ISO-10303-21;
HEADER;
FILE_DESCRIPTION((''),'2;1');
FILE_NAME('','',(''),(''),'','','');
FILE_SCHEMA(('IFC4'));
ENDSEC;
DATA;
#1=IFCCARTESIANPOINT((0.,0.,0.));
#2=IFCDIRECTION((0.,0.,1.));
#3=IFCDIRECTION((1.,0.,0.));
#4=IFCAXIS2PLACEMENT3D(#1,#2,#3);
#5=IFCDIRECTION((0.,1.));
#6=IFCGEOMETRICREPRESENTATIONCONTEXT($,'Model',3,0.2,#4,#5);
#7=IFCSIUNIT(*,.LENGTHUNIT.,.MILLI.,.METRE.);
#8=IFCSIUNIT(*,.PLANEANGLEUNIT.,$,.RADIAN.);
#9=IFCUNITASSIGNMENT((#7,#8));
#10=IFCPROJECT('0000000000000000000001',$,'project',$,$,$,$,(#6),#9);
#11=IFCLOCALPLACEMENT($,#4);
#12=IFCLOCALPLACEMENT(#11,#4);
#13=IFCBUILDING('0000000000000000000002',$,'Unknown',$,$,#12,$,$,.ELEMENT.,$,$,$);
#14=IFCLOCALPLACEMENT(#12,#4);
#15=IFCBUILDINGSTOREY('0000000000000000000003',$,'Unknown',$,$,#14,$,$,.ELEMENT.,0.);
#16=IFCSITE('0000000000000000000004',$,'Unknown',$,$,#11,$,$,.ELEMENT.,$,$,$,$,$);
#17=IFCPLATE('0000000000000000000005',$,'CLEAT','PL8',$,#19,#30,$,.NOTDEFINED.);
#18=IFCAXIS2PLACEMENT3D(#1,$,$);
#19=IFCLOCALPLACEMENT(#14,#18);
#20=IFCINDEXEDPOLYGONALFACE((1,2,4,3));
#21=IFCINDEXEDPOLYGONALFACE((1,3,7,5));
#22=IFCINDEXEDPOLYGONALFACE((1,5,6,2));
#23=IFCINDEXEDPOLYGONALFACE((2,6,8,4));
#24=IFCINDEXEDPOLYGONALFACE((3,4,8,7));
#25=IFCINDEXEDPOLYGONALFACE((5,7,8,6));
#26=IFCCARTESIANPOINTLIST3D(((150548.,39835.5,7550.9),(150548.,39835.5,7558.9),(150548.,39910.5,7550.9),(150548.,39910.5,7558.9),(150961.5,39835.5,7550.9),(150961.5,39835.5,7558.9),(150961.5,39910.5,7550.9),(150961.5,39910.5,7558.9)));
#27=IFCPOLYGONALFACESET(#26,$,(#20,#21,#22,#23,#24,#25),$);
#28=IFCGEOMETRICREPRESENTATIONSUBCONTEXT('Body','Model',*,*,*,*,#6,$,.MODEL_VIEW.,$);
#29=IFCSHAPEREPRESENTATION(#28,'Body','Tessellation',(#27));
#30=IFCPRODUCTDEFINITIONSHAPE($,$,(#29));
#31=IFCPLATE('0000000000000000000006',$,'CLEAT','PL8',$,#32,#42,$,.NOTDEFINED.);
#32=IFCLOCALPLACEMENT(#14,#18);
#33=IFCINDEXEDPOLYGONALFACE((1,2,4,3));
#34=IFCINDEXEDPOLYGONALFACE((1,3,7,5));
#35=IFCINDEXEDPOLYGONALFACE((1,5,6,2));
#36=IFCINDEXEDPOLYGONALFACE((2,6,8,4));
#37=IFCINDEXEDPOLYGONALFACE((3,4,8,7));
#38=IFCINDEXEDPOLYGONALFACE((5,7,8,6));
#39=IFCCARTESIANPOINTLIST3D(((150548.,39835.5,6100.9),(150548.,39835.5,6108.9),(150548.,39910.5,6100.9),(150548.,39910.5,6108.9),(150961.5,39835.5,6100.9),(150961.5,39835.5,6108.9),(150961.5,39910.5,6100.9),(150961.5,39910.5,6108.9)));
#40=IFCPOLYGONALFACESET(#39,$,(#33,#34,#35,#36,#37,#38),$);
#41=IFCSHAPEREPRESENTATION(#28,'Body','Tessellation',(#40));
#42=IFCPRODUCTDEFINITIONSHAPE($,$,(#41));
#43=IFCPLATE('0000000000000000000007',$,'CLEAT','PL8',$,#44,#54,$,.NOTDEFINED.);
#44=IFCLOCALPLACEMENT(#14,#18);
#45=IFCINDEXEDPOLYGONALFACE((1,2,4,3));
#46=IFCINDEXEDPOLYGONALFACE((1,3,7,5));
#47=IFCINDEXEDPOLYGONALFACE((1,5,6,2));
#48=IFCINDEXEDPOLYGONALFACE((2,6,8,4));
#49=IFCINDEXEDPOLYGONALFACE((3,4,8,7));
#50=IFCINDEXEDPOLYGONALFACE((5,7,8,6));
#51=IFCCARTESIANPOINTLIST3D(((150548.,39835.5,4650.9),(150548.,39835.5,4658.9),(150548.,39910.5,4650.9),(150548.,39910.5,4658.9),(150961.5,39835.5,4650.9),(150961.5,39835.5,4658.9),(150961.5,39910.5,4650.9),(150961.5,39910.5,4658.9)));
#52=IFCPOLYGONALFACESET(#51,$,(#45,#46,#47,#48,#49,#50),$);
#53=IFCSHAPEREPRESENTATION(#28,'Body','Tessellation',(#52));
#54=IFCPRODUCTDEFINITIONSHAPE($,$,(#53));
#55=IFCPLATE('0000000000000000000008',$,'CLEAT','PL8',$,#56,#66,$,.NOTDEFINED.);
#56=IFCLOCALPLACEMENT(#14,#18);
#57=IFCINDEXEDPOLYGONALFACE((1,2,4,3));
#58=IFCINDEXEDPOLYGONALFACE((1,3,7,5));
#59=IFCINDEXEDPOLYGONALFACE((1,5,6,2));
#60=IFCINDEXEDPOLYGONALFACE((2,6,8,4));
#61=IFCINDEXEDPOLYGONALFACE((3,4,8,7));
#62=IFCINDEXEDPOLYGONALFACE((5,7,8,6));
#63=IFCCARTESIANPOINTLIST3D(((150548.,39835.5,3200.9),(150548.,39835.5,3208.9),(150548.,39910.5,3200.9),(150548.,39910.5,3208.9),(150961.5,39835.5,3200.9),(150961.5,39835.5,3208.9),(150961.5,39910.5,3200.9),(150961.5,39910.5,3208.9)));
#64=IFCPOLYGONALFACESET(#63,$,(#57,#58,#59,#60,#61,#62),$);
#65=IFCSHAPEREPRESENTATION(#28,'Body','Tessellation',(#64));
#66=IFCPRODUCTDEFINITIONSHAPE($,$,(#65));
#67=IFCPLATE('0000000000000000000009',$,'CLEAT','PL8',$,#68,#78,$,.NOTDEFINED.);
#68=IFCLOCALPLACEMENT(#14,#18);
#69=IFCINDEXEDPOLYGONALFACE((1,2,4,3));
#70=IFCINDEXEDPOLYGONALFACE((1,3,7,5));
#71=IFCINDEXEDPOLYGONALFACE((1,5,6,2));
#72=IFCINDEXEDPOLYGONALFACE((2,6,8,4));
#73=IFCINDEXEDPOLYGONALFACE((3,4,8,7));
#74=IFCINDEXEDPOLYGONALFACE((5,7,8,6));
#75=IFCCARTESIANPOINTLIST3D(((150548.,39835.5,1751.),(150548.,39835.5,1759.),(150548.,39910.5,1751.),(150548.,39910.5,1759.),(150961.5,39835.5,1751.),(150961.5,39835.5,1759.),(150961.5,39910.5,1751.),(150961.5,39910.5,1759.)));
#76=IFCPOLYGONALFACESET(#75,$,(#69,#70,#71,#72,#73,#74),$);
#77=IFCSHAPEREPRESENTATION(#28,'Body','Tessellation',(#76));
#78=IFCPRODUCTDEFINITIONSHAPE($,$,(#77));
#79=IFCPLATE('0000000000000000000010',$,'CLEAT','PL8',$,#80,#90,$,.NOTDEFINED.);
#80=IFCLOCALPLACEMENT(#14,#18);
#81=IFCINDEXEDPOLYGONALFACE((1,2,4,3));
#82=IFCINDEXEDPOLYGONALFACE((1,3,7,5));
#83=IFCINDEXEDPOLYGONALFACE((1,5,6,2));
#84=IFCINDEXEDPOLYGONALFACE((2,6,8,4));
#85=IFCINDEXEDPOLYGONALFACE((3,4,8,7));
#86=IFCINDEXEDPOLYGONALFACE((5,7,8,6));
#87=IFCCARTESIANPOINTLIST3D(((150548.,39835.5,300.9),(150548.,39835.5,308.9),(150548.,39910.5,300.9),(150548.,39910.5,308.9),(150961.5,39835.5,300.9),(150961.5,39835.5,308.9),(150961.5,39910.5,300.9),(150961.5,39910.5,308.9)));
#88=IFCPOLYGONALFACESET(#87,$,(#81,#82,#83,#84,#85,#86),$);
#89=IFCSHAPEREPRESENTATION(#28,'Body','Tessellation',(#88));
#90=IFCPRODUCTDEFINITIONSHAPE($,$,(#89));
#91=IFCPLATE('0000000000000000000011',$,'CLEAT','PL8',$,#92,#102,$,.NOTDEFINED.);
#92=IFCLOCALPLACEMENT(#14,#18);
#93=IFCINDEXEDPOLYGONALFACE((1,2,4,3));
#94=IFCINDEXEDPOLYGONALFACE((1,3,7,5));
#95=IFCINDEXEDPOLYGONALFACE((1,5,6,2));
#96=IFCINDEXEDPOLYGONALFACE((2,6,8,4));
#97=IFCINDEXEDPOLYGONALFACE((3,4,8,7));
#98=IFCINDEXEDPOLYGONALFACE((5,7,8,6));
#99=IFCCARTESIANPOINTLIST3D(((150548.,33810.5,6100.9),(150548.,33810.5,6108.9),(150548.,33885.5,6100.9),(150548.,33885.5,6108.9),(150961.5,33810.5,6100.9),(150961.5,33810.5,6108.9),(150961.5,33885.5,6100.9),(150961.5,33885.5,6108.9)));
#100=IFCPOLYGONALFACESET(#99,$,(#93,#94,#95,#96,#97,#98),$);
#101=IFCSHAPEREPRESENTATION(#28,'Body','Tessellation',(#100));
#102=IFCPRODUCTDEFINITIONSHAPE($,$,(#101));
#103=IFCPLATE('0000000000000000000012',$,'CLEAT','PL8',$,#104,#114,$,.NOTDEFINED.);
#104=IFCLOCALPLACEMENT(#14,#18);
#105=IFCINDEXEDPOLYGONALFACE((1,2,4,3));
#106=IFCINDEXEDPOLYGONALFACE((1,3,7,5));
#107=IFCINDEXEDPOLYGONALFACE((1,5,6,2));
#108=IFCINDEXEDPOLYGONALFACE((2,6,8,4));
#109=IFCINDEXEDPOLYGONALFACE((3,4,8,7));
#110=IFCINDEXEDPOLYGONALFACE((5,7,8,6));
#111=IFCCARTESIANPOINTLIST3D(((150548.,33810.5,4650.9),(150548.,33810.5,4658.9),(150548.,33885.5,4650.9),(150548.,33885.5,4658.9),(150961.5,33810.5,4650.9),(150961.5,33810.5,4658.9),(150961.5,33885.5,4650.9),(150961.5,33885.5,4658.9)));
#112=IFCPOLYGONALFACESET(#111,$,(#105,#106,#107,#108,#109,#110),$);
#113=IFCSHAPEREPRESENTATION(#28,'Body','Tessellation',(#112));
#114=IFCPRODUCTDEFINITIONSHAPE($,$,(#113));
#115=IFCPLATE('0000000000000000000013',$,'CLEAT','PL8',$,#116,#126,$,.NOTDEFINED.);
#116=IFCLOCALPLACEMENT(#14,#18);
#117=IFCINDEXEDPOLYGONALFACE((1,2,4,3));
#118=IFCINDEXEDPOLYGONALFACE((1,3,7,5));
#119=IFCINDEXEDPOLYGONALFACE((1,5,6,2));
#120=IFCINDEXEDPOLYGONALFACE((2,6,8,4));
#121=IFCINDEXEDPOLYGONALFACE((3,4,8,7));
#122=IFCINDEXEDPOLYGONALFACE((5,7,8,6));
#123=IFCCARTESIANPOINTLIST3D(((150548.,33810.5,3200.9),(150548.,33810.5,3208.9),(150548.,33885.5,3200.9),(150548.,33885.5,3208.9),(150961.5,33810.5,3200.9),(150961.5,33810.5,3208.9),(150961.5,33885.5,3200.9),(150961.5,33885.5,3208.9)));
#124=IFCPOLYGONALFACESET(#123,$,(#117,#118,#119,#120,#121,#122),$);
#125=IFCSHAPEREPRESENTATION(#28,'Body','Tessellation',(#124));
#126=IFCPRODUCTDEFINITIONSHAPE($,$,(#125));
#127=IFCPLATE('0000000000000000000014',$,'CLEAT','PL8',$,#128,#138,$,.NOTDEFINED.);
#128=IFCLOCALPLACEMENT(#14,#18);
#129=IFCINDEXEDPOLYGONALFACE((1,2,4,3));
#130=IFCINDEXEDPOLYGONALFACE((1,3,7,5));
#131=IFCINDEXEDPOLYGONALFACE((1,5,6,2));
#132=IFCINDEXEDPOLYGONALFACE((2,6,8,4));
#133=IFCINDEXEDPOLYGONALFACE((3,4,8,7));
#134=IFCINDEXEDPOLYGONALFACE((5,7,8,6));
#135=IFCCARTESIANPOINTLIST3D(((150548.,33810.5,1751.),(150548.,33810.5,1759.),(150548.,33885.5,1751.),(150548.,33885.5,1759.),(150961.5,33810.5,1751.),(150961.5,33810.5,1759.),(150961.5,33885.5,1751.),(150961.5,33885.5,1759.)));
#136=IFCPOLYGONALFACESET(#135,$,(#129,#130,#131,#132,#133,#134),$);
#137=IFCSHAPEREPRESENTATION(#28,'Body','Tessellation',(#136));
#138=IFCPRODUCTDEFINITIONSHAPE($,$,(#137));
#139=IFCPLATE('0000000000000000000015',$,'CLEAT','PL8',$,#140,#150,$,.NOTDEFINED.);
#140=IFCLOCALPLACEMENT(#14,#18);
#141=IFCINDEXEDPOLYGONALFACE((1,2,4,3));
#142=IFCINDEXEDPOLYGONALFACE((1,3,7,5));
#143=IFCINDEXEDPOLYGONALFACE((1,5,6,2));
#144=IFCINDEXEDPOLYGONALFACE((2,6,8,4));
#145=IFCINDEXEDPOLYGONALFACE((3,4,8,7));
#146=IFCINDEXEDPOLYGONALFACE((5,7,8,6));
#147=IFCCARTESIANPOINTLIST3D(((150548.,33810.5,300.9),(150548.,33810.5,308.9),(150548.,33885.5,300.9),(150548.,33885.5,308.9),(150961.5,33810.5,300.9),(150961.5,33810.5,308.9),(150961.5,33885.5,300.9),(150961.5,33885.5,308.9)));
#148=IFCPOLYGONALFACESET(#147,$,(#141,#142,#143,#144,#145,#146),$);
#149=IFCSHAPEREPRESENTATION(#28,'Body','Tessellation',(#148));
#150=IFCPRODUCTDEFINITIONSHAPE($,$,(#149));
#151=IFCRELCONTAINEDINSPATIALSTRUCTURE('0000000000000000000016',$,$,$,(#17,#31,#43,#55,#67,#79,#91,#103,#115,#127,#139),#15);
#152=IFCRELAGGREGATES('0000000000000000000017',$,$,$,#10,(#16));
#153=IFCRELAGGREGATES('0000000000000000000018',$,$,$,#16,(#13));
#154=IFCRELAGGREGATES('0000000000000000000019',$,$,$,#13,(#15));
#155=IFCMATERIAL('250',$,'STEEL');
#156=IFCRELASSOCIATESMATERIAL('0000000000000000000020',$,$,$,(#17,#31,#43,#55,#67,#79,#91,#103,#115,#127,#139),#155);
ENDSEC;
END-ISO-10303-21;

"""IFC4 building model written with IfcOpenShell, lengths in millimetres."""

from ifc_helpers import new_model, si_unit, direction, frame, origin_with_axes, place, context, subcontext, project, spatial, line, indexed_curve, outline, extrude, material, element, save


model = new_model("IFC4")

# Units and contexts
model_context = context("Model", 3, precision=0.2, world=origin_with_axes(), true_north=direction((0.0, 1.0)))
body_context = subcontext(model_context, "Body", "Model", "MODEL_VIEW")
ifc_project = project(units=[si_unit("LENGTHUNIT", "METRE", prefix="MILLI"), si_unit("PLANEANGLEUNIT", "RADIAN")], contexts=[model_context])

# Site, building, storey
site_placement = place(None, origin_with_axes())
site = spatial("IfcSite", under=ifc_project, at=site_placement, Name="Unknown", CompositionType="ELEMENT")
building_placement = place(site_placement, origin_with_axes())
building = spatial("IfcBuilding", under=site, at=building_placement, Name="Unknown", CompositionType="ELEMENT")
storey_placement = place(building_placement, origin_with_axes())
storey = spatial("IfcBuildingStorey", under=building, at=storey_placement, Name="Unknown", CompositionType="ELEMENT", Elevation=0.0)

# Plates
ifc_material_1 = material(Name="250", Category="STEEL")
for number, where, z_axis, x_axis, name in (
    (1, (150961.5, 39835.5, 7554.9), (0.0, 0.0, 1.0), (0.0, 1.0, 0.0), "CLEAT"),
    (2, (150961.5, 39835.5, 6104.9), (0.0, 0.0, 1.0), (0.0, 1.0, 0.0), "CLEAT"),
    (3, (150961.5, 39835.5, 4654.9), (0.0, 0.0, 1.0), (0.0, 1.0, 0.0), "CLEAT"),
    (4, (150961.5, 39835.5, 3204.9), (0.0, 0.0, 1.0), (0.0, 1.0, 0.0), "CLEAT"),
    (5, (150961.5, 39835.5, 1755.0), (0.0, 0.0, 1.0), (0.0, 1.0, 0.0), "CLEAT"),
    (6, (150961.5, 39835.5, 304.9), (0.0, 0.0, 1.0), (0.0, 1.0, 0.0), "CLEAT"),
    (7, (150961.5, 33810.5, 6104.9), (0.0, 0.0, 1.0), (0.0, 1.0, 0.0), "CLEAT"),
    (8, (150961.5, 33810.5, 4654.9), (0.0, 0.0, 1.0), (0.0, 1.0, 0.0), "CLEAT"),
    (9, (150961.5, 33810.5, 3204.9), (0.0, 0.0, 1.0), (0.0, 1.0, 0.0), "CLEAT"),
    (10, (150961.5, 33810.5, 1755.0), (0.0, 0.0, 1.0), (0.0, 1.0, 0.0), "CLEAT"),
    (11, (150961.5, 33810.5, 304.9), (0.0, 0.0, 1.0), (0.0, 1.0, 0.0), "CLEAT"),
):
    element("IfcPlate", number, at=place(storey_placement, frame(where, z_axis=z_axis, x_axis=x_axis)), inside=storey, material=ifc_material_1, Name=name, Description="PL8", PredefinedType="NOTDEFINED", context=body_context, shape_type="SolidModel", body=[
        extrude(outline(indexed_curve([(0.0, 0.0), (75.0, 0.0), (75.0, 413.5), (0.0, 413.5)], segments=[line(1, 2, 3, 4, 1)])), frame((0.0, 0.0, 4.0), z_axis=(0.0, 0.0, 1.0), x_axis=(1.0, 0.0, 0.0)), (0.0, 0.0, -1.0), 8.0),
    ])

save(model, "model.ifc")
